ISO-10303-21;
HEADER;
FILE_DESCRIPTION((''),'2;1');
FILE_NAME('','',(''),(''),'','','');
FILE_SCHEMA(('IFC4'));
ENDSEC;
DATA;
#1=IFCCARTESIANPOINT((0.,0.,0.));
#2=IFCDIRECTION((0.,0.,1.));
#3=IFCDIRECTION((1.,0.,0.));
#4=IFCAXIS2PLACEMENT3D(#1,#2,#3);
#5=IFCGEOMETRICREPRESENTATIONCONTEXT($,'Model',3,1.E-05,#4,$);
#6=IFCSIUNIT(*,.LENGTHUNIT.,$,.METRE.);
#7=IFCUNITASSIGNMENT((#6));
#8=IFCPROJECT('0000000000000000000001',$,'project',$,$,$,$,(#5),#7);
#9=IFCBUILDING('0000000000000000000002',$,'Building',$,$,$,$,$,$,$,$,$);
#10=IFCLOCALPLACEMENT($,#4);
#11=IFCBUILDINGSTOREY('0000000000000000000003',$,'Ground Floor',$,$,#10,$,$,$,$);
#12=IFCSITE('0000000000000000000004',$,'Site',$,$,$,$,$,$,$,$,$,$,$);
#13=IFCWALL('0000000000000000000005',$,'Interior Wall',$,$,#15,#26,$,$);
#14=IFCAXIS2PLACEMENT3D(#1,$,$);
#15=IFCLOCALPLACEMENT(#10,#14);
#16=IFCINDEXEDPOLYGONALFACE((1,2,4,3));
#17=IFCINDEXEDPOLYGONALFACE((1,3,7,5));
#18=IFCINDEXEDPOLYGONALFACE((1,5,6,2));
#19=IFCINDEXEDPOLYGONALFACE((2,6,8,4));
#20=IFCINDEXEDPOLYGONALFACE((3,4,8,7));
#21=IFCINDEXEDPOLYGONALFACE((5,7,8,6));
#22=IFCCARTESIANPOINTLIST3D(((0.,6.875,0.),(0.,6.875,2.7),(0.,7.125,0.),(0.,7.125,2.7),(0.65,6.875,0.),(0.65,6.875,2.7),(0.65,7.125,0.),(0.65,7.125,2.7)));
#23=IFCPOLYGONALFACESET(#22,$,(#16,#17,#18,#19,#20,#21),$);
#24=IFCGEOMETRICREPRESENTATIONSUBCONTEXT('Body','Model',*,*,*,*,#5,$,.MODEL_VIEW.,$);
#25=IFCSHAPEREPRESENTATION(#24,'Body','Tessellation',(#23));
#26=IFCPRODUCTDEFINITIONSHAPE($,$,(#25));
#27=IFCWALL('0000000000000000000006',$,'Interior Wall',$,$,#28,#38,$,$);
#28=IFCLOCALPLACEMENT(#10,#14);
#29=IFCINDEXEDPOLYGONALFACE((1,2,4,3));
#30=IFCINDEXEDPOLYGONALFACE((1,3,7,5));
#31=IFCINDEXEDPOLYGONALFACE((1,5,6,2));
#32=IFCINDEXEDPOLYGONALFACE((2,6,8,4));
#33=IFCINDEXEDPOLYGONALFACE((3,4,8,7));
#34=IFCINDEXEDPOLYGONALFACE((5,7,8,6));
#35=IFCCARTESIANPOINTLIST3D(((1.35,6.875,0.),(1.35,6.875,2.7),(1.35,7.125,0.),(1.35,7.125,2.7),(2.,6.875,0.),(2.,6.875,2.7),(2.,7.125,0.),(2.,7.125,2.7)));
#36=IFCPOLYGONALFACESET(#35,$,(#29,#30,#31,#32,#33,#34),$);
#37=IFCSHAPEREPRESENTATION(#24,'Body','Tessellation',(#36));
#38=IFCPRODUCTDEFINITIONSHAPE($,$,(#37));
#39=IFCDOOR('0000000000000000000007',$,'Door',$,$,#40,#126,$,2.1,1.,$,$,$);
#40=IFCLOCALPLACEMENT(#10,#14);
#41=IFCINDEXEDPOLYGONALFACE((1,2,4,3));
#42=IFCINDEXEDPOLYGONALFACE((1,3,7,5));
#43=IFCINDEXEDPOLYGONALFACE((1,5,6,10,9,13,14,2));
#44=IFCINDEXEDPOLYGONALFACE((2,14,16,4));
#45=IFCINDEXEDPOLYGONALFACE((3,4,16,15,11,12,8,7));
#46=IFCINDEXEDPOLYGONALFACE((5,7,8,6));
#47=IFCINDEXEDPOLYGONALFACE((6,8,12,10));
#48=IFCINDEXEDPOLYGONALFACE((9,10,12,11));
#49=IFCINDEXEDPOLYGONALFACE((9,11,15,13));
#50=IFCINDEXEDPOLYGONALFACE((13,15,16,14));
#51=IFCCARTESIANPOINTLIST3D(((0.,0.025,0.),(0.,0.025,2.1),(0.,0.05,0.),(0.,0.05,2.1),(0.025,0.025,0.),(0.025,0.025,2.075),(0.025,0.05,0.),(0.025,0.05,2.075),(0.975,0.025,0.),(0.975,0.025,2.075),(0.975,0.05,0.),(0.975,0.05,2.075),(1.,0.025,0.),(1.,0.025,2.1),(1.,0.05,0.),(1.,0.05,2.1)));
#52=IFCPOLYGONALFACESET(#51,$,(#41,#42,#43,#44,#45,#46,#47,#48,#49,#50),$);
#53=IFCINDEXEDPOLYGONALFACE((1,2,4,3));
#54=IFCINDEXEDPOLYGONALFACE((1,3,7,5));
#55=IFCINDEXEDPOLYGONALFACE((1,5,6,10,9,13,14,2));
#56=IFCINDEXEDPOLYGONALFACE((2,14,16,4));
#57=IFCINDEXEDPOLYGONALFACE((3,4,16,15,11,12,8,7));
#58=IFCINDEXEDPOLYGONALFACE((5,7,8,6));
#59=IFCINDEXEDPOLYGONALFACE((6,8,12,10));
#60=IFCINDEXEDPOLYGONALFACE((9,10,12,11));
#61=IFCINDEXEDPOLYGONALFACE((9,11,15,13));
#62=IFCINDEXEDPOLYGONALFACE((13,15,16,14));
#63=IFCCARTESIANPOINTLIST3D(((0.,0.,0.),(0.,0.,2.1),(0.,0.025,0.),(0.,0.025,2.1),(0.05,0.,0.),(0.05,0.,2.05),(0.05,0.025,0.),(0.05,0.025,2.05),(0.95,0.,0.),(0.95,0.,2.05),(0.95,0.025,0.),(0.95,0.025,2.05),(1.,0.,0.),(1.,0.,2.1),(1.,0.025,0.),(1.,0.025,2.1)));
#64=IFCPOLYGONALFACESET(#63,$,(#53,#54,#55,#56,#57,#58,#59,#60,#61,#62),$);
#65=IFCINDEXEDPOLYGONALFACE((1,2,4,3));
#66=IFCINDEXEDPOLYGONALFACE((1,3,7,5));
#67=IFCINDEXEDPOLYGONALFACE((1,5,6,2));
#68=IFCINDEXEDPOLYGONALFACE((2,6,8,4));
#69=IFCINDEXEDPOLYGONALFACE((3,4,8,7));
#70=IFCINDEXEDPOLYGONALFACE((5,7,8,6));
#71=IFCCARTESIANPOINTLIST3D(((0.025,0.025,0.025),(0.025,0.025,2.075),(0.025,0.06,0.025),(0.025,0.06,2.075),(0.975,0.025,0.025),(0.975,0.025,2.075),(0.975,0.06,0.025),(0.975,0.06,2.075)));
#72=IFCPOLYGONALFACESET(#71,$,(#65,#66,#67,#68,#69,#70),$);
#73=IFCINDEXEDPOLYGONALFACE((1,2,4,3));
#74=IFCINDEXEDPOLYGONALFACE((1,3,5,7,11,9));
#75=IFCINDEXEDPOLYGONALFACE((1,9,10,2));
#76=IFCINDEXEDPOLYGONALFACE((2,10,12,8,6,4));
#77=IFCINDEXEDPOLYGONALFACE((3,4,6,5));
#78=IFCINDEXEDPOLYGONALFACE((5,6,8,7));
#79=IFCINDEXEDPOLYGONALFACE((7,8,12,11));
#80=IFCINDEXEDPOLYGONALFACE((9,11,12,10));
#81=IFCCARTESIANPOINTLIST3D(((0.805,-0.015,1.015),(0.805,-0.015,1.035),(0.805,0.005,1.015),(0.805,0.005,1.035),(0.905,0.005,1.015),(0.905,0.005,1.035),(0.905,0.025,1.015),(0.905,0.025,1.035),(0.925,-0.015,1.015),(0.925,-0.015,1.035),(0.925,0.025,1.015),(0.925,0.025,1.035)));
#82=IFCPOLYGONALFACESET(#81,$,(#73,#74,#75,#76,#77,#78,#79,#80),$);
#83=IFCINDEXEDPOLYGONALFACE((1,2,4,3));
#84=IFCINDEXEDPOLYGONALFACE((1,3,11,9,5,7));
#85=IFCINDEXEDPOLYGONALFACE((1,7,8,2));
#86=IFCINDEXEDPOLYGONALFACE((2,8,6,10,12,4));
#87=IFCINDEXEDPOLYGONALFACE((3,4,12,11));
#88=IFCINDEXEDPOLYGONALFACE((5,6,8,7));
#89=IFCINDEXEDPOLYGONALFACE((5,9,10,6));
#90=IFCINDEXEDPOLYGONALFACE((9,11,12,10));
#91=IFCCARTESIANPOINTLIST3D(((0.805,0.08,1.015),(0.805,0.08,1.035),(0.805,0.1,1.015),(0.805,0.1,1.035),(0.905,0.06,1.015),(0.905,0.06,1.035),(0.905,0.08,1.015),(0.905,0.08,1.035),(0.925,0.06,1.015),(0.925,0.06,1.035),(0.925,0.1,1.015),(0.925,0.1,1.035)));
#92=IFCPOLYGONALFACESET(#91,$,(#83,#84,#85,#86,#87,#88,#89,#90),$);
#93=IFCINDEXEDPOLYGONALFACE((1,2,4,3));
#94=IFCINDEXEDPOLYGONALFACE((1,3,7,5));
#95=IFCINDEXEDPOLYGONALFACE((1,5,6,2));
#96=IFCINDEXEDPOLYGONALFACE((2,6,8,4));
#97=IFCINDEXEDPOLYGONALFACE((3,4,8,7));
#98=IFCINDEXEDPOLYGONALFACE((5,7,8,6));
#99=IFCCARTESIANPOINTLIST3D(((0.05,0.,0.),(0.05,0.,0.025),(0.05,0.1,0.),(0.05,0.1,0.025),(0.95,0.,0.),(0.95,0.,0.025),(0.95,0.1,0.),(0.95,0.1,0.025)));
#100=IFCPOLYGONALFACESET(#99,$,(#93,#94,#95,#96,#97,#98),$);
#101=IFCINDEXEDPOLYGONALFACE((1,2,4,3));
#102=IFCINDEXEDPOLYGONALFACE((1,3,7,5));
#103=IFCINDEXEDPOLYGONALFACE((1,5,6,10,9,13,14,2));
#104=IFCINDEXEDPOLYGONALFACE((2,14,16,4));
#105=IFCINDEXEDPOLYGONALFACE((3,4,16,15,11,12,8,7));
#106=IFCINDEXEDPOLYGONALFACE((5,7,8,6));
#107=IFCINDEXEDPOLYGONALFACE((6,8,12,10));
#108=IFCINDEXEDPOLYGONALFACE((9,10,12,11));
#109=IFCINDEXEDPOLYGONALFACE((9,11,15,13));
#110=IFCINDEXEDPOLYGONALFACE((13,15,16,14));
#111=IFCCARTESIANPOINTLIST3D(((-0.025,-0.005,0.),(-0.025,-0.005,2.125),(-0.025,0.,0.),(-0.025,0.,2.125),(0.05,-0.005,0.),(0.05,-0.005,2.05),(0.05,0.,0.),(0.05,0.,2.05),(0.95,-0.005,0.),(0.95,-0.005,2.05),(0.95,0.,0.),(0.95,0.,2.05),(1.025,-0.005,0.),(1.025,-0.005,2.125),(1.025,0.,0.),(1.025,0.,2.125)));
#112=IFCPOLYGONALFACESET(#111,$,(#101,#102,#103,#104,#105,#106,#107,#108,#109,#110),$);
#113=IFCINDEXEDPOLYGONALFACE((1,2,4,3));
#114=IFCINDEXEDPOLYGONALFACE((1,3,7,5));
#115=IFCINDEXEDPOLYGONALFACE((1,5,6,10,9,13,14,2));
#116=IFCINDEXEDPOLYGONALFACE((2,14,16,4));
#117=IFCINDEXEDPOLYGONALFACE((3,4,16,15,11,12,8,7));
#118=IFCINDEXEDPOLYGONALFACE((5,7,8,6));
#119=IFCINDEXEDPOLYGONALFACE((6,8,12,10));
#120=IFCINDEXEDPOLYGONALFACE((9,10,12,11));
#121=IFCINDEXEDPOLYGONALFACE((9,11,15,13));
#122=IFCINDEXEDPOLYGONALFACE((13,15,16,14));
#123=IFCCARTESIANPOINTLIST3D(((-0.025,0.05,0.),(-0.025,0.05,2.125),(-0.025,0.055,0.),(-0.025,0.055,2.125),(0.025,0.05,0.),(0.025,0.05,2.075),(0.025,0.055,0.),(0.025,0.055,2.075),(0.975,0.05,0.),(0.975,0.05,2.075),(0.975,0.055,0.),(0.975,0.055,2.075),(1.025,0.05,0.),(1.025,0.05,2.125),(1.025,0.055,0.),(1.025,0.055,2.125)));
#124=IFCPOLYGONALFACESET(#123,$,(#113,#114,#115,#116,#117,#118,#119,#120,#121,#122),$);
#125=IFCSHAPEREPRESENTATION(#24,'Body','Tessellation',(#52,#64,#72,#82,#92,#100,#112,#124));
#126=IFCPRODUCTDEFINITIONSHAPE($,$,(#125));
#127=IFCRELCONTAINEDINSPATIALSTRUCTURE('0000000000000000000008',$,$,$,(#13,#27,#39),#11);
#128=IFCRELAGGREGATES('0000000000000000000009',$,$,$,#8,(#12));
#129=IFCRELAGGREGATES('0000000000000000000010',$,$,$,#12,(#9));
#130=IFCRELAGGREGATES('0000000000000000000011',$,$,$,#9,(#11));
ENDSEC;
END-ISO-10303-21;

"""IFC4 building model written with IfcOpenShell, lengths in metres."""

from ifc_helpers import new_model, si_unit, frame, origin_with_axes, place, context, subcontext, project, spatial, line, indexed_curve, outline, extrude, element, save


model = new_model("IFC4")

# Units and contexts
model_context = context("Model", 3, precision=1e-05, world=origin_with_axes())
body_context = subcontext(model_context, "Body", "Model", "MODEL_VIEW")
ifc_project = project(units=[si_unit("LENGTHUNIT", "METRE")], contexts=[model_context])

# Site, building, storey
site = spatial("IfcSite", under=ifc_project, Name="Site")
building = spatial("IfcBuilding", under=site, Name="Building")
storey_placement = place(None, origin_with_axes())
storey = spatial("IfcBuildingStorey", under=building, at=storey_placement, Name="Ground Floor")

# Walls
wall_1_placement = place(storey_placement, frame((0.0, 7.0, 0.0), z_axis=(0.0, 0.0, 1.0), x_axis=(1.0, 0.0, 0.0)))
element("IfcWall", 1, at=wall_1_placement, inside=storey, Name="Interior Wall", context=body_context, shape_type="SweptSolid", body=[
    extrude(outline(indexed_curve([(0.0, 0.0), (0.0, 0.25), (0.65, 0.25), (0.65, 0.0), (0.0, 0.0)], self_intersect=False)), frame((0.0, -0.125, 0.0), z_axis=(0.0, 0.0, 1.0), x_axis=(1.0, 0.0, 0.0)), (0.0, 0.0, 1.0), 2.7),
])
wall_2_placement = place(storey_placement, frame((1.35, 7.0, 0.0), z_axis=(0.0, 0.0, 1.0), x_axis=(1.0, 0.0, 0.0)))
element("IfcWall", 2, at=wall_2_placement, inside=storey, Name="Interior Wall", context=body_context, shape_type="SweptSolid", body=[
    extrude(outline(indexed_curve([(0.0, 0.0), (0.0, 0.25), (0.65, 0.25), (0.65, 0.0), (0.0, 0.0)], self_intersect=False)), frame((0.0, -0.125, 0.0), z_axis=(0.0, 0.0, 1.0), x_axis=(1.0, 0.0, 0.0)), (0.0, 0.0, 1.0), 2.7),
])

# Door
door_1_placement = place(storey_placement, origin_with_axes())
element("IfcDoor", 3, at=door_1_placement, inside=storey, Name="Door", OverallHeight=2.1, OverallWidth=1.0, context=body_context, shape_type="SweptSolid", body=[
    extrude(outline(indexed_curve([(0.0, 0.0), (0.0, 2.1), (1.0, 2.1), (1.0, 0.0), (0.975, 0.0), (0.975, 2.075), (0.025, 2.075), (0.025, 0.0)], segments=[line(1, 2, 3, 4, 5, 6, 7, 8, 1)])), frame((0.0, 0.025, 0.0), z_axis=(0.0, -1.0, 0.0), x_axis=(1.0, 0.0, 0.0)), (0.0, 0.0, -1.0), 0.025),
    extrude(outline(indexed_curve([(0.0, 0.0), (0.0, 2.1), (1.0, 2.1), (1.0, 0.0), (0.95, 0.0), (0.95, 2.05), (0.05, 2.05), (0.05, 0.0)], segments=[line(1, 2, 3, 4, 5, 6, 7, 8, 1)])), frame((0.0, 0.0, 0.0), z_axis=(0.0, -1.0, 0.0), x_axis=(1.0, 0.0, 0.0)), (0.0, 0.0, -1.0), 0.025),
    extrude(outline(indexed_curve([(0.0, 0.0), (0.95, 0.0), (0.95, 0.035), (0.0, 0.035)], segments=[line(1, 2, 3, 4, 1)])), frame((0.025, 0.025, 0.025), z_axis=(0.0, 0.0, 1.0), x_axis=(1.0, 0.0, 0.0)), (0.0, 0.0, 1.0), 2.05),
    extrude(outline(indexed_curve([(0.0, 0.0), (0.0, -0.04), (-0.12, -0.04), (-0.12, -0.02), (-0.02, -0.02), (-0.02, 0.0)], segments=[line(1, 2, 3, 4, 5, 6, 1)])), frame((0.925, 0.025, 1.015), z_axis=(0.0, 0.0, 1.0), x_axis=(1.0, 0.0, 0.0)), (0.0, 0.0, 1.0), 0.02),
    extrude(outline(indexed_curve([(0.0, 0.0), (0.0, 0.04), (-0.12, 0.04), (-0.12, 0.02), (-0.02, 0.02), (-0.02, 0.0)], segments=[line(1, 2, 3, 4, 5, 6, 1)])), frame((0.925, 0.06, 1.015), z_axis=(0.0, 0.0, 1.0), x_axis=(1.0, 0.0, 0.0)), (0.0, 0.0, 1.0), 0.02),
    extrude(outline(indexed_curve([(0.0, 0.0), (0.9, 0.0), (0.9, 0.1), (0.0, 0.1)], segments=[line(1, 2, 3, 4, 1)])), frame((0.05, 0.0, 0.0), z_axis=(0.0, 0.0, 1.0), x_axis=(1.0, 0.0, 0.0)), (0.0, 0.0, 1.0), 0.025),
    extrude(outline(indexed_curve([(0.0, 0.0), (0.0, 2.125), (1.05, 2.125), (1.05, 0.0), (0.975, 0.0), (0.975, 2.05), (0.075, 2.05), (0.075, 0.0)], segments=[line(1, 2, 3, 4, 5, 6, 7, 8, 1)])), frame((-0.025, -0.005, 0.0), z_axis=(0.0, -1.0, 0.0), x_axis=(1.0, 0.0, 0.0)), (0.0, 0.0, -1.0), 0.005),
    extrude(outline(indexed_curve([(0.0, 0.0), (0.0, 2.125), (1.05, 2.125), (1.05, 0.0), (1.0, 0.0), (1.0, 2.075), (0.05, 2.075), (0.05, 0.0)], segments=[line(1, 2, 3, 4, 5, 6, 7, 8, 1)])), frame((-0.025, 0.05, 0.0), z_axis=(0.0, -1.0, 0.0), x_axis=(1.0, 0.0, 0.0)), (0.0, 0.0, -1.0), 0.005),
])

save(model, "model.ifc")
